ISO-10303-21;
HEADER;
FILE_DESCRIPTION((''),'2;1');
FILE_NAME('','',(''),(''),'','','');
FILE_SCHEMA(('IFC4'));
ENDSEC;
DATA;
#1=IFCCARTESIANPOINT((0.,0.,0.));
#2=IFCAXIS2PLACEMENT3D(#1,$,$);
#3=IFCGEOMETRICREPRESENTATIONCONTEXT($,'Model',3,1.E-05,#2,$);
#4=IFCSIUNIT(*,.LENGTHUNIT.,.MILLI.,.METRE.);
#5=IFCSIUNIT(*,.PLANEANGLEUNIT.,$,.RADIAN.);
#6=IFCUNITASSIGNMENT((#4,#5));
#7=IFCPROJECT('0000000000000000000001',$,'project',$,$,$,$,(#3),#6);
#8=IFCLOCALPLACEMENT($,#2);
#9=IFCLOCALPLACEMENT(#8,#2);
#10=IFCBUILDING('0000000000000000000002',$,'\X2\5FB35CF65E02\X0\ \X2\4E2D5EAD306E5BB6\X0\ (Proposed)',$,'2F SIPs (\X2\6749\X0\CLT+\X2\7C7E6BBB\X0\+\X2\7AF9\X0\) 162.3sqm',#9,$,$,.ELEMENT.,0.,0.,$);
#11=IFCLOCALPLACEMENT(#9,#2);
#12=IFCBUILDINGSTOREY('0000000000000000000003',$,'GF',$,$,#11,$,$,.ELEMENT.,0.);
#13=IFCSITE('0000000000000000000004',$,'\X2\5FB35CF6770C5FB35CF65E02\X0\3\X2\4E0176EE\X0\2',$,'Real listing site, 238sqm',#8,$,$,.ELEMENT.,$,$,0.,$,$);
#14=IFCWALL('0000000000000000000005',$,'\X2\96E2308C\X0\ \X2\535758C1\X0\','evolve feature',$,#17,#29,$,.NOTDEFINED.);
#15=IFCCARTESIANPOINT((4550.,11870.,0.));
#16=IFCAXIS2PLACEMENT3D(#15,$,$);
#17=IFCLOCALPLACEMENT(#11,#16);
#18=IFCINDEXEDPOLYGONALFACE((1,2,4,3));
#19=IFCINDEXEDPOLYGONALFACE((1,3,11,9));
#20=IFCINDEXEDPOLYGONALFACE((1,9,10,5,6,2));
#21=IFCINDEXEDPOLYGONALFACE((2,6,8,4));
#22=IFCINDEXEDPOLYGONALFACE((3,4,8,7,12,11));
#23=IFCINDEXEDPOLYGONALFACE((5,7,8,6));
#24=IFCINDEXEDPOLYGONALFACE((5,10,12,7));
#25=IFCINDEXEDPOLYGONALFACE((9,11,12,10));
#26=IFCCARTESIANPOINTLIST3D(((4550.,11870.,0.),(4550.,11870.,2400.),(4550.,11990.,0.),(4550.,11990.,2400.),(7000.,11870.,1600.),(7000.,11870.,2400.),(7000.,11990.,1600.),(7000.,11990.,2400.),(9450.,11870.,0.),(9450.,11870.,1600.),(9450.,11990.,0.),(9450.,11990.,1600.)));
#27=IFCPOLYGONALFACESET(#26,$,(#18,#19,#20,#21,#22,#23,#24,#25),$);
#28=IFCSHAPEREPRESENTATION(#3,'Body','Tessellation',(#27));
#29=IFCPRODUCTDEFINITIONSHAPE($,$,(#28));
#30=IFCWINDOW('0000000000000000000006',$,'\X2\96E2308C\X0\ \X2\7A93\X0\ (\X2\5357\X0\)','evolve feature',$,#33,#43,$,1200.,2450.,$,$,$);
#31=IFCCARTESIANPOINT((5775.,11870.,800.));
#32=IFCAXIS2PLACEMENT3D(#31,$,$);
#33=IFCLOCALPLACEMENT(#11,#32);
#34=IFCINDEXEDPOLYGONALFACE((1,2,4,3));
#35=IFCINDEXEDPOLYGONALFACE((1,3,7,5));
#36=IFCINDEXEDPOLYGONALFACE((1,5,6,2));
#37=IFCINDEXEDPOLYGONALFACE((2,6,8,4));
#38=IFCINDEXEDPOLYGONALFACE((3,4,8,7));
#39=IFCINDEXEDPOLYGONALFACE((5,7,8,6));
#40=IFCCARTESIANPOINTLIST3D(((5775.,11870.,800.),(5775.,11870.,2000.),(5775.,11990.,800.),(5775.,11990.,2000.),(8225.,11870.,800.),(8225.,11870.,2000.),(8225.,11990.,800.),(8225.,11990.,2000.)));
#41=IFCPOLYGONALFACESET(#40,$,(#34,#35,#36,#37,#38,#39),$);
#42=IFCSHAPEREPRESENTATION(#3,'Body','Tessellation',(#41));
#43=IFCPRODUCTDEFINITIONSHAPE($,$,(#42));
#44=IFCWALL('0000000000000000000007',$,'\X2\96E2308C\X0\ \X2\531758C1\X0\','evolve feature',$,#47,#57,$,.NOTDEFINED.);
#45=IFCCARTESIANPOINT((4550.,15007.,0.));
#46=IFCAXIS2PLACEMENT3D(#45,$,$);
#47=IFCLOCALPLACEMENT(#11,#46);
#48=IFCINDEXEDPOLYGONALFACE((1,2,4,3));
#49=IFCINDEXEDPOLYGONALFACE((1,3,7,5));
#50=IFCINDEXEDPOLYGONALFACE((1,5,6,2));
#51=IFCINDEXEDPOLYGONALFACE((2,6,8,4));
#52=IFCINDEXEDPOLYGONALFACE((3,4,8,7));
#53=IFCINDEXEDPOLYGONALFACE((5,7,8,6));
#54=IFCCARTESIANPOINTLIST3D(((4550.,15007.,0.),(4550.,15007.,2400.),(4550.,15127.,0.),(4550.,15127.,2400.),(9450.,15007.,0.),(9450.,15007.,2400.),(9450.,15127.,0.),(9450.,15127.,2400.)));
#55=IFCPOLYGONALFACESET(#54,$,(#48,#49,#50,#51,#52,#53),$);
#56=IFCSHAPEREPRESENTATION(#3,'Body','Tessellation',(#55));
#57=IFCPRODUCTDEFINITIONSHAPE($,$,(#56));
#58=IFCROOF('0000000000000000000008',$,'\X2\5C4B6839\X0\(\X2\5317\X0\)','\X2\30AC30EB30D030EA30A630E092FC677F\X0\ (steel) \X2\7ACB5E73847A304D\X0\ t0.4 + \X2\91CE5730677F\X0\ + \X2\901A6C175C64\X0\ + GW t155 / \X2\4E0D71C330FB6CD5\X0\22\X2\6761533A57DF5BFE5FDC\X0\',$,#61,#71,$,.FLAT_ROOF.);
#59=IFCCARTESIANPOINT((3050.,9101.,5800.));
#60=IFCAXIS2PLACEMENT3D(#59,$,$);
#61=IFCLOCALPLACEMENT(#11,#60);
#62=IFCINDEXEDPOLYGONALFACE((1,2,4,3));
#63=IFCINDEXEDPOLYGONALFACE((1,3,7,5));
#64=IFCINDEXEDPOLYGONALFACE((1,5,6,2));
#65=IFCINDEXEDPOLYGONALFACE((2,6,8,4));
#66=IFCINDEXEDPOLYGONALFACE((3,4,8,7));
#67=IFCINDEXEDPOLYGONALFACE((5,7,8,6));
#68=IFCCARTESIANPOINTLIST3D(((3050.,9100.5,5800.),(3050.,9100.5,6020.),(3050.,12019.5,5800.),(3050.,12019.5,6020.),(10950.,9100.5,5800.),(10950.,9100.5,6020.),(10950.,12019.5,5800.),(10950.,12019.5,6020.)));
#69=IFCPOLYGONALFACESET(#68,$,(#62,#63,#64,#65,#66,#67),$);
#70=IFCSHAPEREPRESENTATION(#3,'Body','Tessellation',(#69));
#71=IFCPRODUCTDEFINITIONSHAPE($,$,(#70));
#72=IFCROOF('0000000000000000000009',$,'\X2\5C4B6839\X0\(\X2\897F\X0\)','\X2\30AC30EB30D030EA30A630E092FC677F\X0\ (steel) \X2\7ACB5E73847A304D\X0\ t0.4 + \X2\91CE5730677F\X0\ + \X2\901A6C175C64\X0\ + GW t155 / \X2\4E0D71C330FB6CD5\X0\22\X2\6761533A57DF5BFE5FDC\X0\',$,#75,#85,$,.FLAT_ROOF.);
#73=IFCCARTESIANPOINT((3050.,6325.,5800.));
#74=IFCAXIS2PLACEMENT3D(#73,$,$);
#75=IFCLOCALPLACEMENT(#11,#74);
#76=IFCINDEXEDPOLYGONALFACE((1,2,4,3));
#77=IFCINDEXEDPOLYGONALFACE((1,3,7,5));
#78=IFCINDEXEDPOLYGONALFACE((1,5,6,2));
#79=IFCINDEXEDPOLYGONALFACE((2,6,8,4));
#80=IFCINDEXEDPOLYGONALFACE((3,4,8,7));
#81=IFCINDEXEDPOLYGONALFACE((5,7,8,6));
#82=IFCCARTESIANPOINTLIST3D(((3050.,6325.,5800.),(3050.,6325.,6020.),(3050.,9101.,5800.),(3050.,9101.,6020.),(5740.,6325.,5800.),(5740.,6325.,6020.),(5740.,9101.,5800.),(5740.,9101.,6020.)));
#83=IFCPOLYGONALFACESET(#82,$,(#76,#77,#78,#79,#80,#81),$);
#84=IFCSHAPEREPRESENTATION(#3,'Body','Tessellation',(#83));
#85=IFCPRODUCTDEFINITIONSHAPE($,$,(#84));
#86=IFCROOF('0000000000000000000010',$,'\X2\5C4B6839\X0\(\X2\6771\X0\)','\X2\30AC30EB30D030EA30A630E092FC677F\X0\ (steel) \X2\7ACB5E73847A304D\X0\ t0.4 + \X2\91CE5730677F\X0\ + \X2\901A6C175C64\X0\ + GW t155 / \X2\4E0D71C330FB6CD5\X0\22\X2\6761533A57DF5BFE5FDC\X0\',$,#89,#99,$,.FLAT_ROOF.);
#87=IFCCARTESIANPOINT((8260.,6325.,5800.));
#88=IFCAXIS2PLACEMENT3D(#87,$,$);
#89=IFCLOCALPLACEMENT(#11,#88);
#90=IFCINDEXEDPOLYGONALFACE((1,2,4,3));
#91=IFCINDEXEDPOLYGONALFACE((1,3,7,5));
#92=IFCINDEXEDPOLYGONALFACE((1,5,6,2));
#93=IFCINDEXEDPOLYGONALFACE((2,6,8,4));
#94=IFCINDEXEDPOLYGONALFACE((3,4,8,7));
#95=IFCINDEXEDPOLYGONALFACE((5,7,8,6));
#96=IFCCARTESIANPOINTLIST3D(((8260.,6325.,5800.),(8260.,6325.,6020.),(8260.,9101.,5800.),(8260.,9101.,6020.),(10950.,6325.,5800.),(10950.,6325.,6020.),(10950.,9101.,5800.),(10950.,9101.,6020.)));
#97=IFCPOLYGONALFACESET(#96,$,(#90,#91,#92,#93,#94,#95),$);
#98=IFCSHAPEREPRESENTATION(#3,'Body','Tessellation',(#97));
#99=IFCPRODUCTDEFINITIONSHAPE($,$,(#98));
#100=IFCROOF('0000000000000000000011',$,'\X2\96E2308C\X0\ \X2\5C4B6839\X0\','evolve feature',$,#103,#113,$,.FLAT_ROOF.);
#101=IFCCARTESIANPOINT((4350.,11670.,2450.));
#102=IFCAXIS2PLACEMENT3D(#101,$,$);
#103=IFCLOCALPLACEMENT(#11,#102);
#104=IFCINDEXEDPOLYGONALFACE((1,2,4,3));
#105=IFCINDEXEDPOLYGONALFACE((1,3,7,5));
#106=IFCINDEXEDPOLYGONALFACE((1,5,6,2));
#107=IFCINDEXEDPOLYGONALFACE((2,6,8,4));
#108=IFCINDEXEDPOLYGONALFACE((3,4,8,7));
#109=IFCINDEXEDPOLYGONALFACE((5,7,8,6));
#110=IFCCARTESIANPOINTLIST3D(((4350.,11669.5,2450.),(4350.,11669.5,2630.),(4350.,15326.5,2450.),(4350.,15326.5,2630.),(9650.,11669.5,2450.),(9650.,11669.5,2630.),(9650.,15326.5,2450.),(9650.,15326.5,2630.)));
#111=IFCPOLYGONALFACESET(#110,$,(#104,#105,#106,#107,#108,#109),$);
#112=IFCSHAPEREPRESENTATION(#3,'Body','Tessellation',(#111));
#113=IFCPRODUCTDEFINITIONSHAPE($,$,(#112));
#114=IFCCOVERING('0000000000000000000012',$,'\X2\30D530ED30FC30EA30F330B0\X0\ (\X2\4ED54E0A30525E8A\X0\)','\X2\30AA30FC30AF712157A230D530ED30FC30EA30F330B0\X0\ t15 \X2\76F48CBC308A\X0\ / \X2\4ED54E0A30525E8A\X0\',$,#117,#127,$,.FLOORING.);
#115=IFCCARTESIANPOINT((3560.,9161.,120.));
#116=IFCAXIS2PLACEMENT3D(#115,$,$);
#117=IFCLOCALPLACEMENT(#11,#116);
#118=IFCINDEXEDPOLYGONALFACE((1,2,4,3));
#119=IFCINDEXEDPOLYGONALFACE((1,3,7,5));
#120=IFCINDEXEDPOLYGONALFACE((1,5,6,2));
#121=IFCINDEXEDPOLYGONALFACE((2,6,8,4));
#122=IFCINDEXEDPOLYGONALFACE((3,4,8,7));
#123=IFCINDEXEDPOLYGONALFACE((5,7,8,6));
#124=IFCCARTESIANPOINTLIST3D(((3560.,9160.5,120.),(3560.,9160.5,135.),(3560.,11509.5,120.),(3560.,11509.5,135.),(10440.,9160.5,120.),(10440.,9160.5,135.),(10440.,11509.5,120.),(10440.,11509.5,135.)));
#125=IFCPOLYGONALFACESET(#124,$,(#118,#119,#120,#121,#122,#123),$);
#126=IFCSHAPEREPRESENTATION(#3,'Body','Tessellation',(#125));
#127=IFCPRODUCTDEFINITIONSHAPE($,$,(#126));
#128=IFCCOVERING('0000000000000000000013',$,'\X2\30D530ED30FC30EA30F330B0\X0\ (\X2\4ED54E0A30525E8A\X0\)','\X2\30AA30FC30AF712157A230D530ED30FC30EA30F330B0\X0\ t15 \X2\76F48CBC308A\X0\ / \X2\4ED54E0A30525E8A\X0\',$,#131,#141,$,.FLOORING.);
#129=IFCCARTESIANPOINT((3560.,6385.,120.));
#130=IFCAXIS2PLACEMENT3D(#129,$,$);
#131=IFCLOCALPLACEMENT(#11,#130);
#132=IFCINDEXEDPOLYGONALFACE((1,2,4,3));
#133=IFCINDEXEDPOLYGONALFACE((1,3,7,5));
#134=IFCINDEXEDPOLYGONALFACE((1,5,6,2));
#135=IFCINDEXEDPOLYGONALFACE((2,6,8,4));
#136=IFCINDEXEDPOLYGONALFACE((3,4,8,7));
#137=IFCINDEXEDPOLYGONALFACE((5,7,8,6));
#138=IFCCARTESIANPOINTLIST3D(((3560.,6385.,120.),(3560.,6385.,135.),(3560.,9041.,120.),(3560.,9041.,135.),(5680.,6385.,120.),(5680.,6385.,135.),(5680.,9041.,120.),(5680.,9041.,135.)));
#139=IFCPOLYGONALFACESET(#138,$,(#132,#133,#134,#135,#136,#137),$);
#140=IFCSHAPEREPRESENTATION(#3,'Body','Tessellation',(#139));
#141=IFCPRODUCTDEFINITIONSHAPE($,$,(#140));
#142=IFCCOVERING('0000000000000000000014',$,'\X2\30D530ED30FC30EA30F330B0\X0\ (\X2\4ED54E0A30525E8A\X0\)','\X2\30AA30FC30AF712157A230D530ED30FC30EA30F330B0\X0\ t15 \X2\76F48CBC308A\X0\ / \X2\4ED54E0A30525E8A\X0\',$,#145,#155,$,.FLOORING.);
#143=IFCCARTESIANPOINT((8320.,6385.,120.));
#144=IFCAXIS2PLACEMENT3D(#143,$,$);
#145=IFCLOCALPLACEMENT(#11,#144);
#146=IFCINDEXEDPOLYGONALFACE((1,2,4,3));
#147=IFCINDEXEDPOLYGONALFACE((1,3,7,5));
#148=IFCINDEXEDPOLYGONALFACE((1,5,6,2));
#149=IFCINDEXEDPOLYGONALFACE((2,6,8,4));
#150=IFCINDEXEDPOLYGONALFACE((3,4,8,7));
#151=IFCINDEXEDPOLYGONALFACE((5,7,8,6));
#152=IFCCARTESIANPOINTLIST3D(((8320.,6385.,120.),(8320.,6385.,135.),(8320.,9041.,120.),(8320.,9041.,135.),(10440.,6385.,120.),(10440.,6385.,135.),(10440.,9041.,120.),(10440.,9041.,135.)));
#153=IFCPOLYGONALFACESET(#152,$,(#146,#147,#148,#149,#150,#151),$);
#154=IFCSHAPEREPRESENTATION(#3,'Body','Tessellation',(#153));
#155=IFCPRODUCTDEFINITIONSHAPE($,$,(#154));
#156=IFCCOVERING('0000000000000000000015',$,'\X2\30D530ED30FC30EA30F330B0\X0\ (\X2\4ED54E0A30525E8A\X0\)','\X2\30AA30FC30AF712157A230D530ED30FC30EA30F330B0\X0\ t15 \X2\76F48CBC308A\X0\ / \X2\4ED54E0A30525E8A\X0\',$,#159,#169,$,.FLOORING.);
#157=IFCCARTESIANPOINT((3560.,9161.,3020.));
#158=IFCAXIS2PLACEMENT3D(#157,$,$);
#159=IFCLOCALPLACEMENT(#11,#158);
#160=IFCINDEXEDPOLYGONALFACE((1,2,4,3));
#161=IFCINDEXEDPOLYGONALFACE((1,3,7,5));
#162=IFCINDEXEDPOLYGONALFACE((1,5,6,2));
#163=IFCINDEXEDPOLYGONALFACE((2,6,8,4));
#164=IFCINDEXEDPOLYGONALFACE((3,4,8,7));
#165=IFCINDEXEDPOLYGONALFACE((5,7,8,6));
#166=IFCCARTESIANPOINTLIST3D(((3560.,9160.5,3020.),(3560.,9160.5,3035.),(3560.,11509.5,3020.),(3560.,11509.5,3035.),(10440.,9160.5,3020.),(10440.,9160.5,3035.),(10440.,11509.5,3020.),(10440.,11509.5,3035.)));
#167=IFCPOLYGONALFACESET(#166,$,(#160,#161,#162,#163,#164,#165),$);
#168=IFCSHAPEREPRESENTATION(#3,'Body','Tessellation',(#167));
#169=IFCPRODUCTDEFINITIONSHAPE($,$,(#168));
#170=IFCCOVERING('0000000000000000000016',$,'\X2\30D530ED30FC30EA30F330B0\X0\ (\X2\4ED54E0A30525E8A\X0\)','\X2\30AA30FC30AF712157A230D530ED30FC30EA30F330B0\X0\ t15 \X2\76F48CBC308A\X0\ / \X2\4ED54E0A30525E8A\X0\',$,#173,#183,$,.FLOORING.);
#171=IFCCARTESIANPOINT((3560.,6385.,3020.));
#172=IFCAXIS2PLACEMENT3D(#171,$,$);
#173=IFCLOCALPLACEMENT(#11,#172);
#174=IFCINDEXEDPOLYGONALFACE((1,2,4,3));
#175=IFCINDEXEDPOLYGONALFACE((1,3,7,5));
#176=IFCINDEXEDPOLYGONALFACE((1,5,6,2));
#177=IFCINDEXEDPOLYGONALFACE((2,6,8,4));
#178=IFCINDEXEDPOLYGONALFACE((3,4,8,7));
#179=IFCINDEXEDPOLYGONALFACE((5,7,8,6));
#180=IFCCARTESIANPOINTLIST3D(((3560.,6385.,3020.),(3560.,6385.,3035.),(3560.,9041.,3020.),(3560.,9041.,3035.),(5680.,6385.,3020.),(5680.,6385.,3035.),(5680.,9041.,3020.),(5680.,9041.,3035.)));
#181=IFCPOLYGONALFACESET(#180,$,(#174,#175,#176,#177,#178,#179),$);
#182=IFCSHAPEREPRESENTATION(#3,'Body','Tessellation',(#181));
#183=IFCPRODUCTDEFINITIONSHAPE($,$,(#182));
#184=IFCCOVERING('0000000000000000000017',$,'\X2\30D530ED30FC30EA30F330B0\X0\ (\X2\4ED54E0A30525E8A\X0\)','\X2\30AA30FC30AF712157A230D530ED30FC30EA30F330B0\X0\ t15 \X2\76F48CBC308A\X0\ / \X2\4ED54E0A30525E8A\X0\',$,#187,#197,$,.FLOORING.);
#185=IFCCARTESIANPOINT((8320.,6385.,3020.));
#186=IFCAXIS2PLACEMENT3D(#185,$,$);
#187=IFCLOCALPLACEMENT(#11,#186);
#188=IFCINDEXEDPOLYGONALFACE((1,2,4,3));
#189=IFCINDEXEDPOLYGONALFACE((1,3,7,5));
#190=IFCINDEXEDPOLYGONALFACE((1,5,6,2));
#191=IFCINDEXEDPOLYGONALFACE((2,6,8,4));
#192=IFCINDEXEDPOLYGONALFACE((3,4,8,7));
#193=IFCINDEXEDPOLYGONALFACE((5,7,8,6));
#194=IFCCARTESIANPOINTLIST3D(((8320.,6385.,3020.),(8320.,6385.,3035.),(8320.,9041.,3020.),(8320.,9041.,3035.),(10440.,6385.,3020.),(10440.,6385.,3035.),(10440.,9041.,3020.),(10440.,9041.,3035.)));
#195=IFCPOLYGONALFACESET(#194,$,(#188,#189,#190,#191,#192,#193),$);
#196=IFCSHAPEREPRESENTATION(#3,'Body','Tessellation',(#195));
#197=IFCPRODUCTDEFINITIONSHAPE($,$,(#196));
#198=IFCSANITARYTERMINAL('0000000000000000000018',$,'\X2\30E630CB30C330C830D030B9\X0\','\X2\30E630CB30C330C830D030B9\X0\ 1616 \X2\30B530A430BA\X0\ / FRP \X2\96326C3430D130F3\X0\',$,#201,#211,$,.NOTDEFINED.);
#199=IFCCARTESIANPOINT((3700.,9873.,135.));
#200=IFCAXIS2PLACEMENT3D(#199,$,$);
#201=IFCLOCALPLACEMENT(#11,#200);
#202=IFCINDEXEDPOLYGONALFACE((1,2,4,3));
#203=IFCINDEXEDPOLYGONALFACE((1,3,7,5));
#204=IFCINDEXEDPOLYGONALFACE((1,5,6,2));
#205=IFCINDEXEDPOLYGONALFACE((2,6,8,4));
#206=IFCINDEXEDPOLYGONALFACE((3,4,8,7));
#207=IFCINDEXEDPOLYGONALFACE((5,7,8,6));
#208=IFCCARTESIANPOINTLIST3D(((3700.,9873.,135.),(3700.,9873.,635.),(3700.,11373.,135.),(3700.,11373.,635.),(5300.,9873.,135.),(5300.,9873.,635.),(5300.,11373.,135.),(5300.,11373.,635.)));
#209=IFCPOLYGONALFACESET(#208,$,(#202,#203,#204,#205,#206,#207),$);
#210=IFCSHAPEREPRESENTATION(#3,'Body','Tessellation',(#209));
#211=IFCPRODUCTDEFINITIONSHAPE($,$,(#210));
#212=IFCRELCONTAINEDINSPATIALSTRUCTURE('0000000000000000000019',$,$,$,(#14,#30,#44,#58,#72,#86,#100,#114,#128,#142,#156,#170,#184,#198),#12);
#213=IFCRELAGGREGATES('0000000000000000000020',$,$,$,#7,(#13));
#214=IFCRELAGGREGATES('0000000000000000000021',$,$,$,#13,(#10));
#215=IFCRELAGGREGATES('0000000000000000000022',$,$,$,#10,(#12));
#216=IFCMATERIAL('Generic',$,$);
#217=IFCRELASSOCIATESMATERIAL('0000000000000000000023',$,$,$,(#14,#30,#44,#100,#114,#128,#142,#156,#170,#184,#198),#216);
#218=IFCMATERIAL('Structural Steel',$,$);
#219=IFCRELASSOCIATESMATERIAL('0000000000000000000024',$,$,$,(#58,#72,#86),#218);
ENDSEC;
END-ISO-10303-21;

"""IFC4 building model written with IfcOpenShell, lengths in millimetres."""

from ifc_helpers import new_model, si_unit, frame, frame_2d, origin, place, context, project, spatial, rectangle, extrude, material, element, fill, save


model = new_model("IFC4")

# Units and contexts
model_context = context("Model", 3, precision=1e-05, world=origin())
ifc_project = project(units=[si_unit("LENGTHUNIT", "METRE", prefix="MILLI"), si_unit("PLANEANGLEUNIT", "RADIAN")], contexts=[model_context])

# Site, building, storey
site_placement = place(None, origin())
site = spatial("IfcSite", under=ifc_project, at=site_placement, Name="徳島県徳島市3丁目2", ObjectType="Real listing site, 238sqm", CompositionType="ELEMENT", RefElevation=0.0)
building_placement = place(site_placement, origin())
building = spatial("IfcBuilding", under=site, at=building_placement, Name="徳島市 中庭の家 (Proposed)", ObjectType="2F SIPs (杉CLT+籾殻+竹) 162.3sqm", CompositionType="ELEMENT", ElevationOfRefHeight=0.0, ElevationOfTerrain=0.0)
storey_placement = place(building_placement, origin())
storey = spatial("IfcBuildingStorey", under=building, at=storey_placement, Name="GF", CompositionType="ELEMENT", Elevation=0.0)

# Shared definitions
ifc_material_1 = material(Name="Generic")

# Wall, opening, window
wall_1_placement = place(storey_placement, frame((4550.0, 11870.0, 0.0)))
wall_1 = element("IfcWall", 1, at=wall_1_placement, inside=storey, material=ifc_material_1, Name="離れ 南壁", Description="evolve feature", PredefinedType="NOTDEFINED", context=model_context, shape_type="SweptSolid", body=[
    extrude(rectangle(XDim=4900.0, YDim=120.0, at=frame_2d((2450.0, 60.0))), frame((4550.0, 11870.0, 0.0)), (0.0, 0.0, 1.0), 2400.0),
])
opening_1_placement = place(storey_placement, frame((5775.0, 11870.0, 800.0)))
opening_1 = element("IfcOpeningElement", 2, at=opening_1_placement, cuts=wall_1, PredefinedType="NOTDEFINED", context=model_context, shape_type="SweptSolid", body=[
    extrude(rectangle(XDim=2450.0, YDim=120.0, at=frame_2d((1225.0, 60.0))), frame((5775.0, 11870.0, 800.0)), (0.0, 0.0, 1.0), 1200.0),
])
window_1_placement = place(storey_placement, frame((5775.0, 11870.0, 800.0)))
window_1 = element("IfcWindow", 3, at=window_1_placement, inside=storey, material=ifc_material_1, Name="離れ 窓 (南)", Description="evolve feature", OverallHeight=1200.0, OverallWidth=2450.0, context=model_context, shape_type="SweptSolid", body=[
    extrude(rectangle(XDim=2450.0, YDim=120.0, at=frame_2d((1225.0, 60.0))), frame((5775.0, 11870.0, 800.0)), (0.0, 0.0, 1.0), 1200.0),
])
fill(opening_1, window_1)

# Wall
wall_2_placement = place(storey_placement, frame((4550.0, 15007.0, 0.0)))
element("IfcWall", 4, at=wall_2_placement, inside=storey, material=ifc_material_1, Name="離れ 北壁", Description="evolve feature", PredefinedType="NOTDEFINED", context=model_context, shape_type="SweptSolid", body=[
    extrude(rectangle(XDim=4900.0, YDim=120.0, at=frame_2d((2450.0, 60.0))), frame((4550.0, 15007.0, 0.0)), (0.0, 0.0, 1.0), 2400.0),
])

# Roofs
ifc_material_2 = material(Name="Structural Steel")
for number, where, name in (
    (5, (3050.0, 9101.0, 5800.0), "屋根(北)"),
):
    element("IfcRoof", number, at=place(storey_placement, frame(where)), inside=storey, material=ifc_material_2, Name=name, Description="ガルバリウム鋼板 (steel) 立平葺き t0.4 + 野地板 + 通気層 + GW t155 / 不燃・法22条区域対応", PredefinedType="FLAT_ROOF", context=model_context, shape_type="SweptSolid", body=[
        extrude(rectangle(XDim=7900.0, YDim=2919.0, at=frame_2d((3950.0, 1459.0))), frame((3050.0, 9101.0, 5800.0)), (0.0, 0.0, 1.0), 220.0),
    ])
roof_1_placement = place(storey_placement, frame((3050.0, 6325.0, 5800.0)))
element("IfcRoof", 6, at=roof_1_placement, inside=storey, material=ifc_material_2, Name="屋根(西)", Description="ガルバリウム鋼板 (steel) 立平葺き t0.4 + 野地板 + 通気層 + GW t155 / 不燃・法22条区域対応", PredefinedType="FLAT_ROOF", context=model_context, shape_type="SweptSolid", body=[
    extrude(rectangle(XDim=2690.0, YDim=2776.0, at=frame_2d((1345.0, 1388.0))), frame((3050.0, 6325.0, 5800.0)), (0.0, 0.0, 1.0), 220.0),
])
roof_2_placement = place(storey_placement, frame((8260.0, 6325.0, 5800.0)))
element("IfcRoof", 7, at=roof_2_placement, inside=storey, material=ifc_material_2, Name="屋根(東)", Description="ガルバリウム鋼板 (steel) 立平葺き t0.4 + 野地板 + 通気層 + GW t155 / 不燃・法22条区域対応", PredefinedType="FLAT_ROOF", context=model_context, shape_type="SweptSolid", body=[
    extrude(rectangle(XDim=2690.0, YDim=2776.0, at=frame_2d((1345.0, 1388.0))), frame((8260.0, 6325.0, 5800.0)), (0.0, 0.0, 1.0), 220.0),
])
roof_3_placement = place(storey_placement, frame((4350.0, 11670.0, 2450.0)))
element("IfcRoof", 8, at=roof_3_placement, inside=storey, material=ifc_material_1, Name="離れ 屋根", Description="evolve feature", PredefinedType="FLAT_ROOF", context=model_context, shape_type="SweptSolid", body=[
    extrude(rectangle(XDim=5300.0, YDim=3657.0, at=frame_2d((2650.0, 1828.0))), frame((4350.0, 11670.0, 2450.0)), (0.0, 0.0, 1.0), 180.0),
])

# Coverings
covering_1_placement = place(storey_placement, frame((3560.0, 9161.0, 120.0)))
element("IfcCovering", 9, at=covering_1_placement, inside=storey, material=ifc_material_1, Name="フローリング (仕上げ床)", Description="オーク無垢フローリング t15 直貼り / 仕上げ床", PredefinedType="FLOORING", context=model_context, shape_type="SweptSolid", body=[
    extrude(rectangle(XDim=6880.0, YDim=2349.0, at=frame_2d((3440.0, 1174.0))), frame((3560.0, 9161.0, 120.0)), (0.0, 0.0, 1.0), 15.0),
])
covering_2_placement = place(storey_placement, frame((3560.0, 6385.0, 120.0)))
element("IfcCovering", 10, at=covering_2_placement, inside=storey, material=ifc_material_1, Name="フローリング (仕上げ床)", Description="オーク無垢フローリング t15 直貼り / 仕上げ床", PredefinedType="FLOORING", context=model_context, shape_type="SweptSolid", body=[
    extrude(rectangle(XDim=2120.0, YDim=2656.0, at=frame_2d((1060.0, 1328.0))), frame((3560.0, 6385.0, 120.0)), (0.0, 0.0, 1.0), 15.0),
])
covering_3_placement = place(storey_placement, frame((8320.0, 6385.0, 120.0)))
element("IfcCovering", 11, at=covering_3_placement, inside=storey, material=ifc_material_1, Name="フローリング (仕上げ床)", Description="オーク無垢フローリング t15 直貼り / 仕上げ床", PredefinedType="FLOORING", context=model_context, shape_type="SweptSolid", body=[
    extrude(rectangle(XDim=2120.0, YDim=2656.0, at=frame_2d((1060.0, 1328.0))), frame((8320.0, 6385.0, 120.0)), (0.0, 0.0, 1.0), 15.0),
])
covering_4_placement = place(storey_placement, frame((3560.0, 9161.0, 3020.0)))
element("IfcCovering", 12, at=covering_4_placement, inside=storey, material=ifc_material_1, Name="フローリング (仕上げ床)", Description="オーク無垢フローリング t15 直貼り / 仕上げ床", PredefinedType="FLOORING", context=model_context, shape_type="SweptSolid", body=[
    extrude(rectangle(XDim=6880.0, YDim=2349.0, at=frame_2d((3440.0, 1174.0))), frame((3560.0, 9161.0, 3020.0)), (0.0, 0.0, 1.0), 15.0),
])
covering_5_placement = place(storey_placement, frame((3560.0, 6385.0, 3020.0)))
element("IfcCovering", 13, at=covering_5_placement, inside=storey, material=ifc_material_1, Name="フローリング (仕上げ床)", Description="オーク無垢フローリング t15 直貼り / 仕上げ床", PredefinedType="FLOORING", context=model_context, shape_type="SweptSolid", body=[
    extrude(rectangle(XDim=2120.0, YDim=2656.0, at=frame_2d((1060.0, 1328.0))), frame((3560.0, 6385.0, 3020.0)), (0.0, 0.0, 1.0), 15.0),
])
covering_6_placement = place(storey_placement, frame((8320.0, 6385.0, 3020.0)))
element("IfcCovering", 14, at=covering_6_placement, inside=storey, material=ifc_material_1, Name="フローリング (仕上げ床)", Description="オーク無垢フローリング t15 直貼り / 仕上げ床", PredefinedType="FLOORING", context=model_context, shape_type="SweptSolid", body=[
    extrude(rectangle(XDim=2120.0, YDim=2656.0, at=frame_2d((1060.0, 1328.0))), frame((8320.0, 6385.0, 3020.0)), (0.0, 0.0, 1.0), 15.0),
])

# Sanitary terminal
sanitary_terminal_1_placement = place(storey_placement, frame((3700.0, 9873.0, 135.0)))
element("IfcSanitaryTerminal", 15, at=sanitary_terminal_1_placement, inside=storey, material=ifc_material_1, Name="ユニットバス", Description="ユニットバス 1616 サイズ / FRP 防水パン", PredefinedType="NOTDEFINED", context=model_context, shape_type="SweptSolid", body=[
    extrude(rectangle(XDim=1600.0, YDim=1500.0, at=frame_2d((800.0, 750.0))), frame((3700.0, 9873.0, 135.0)), (0.0, 0.0, 1.0), 500.0),
])

save(model, "model.ifc")
